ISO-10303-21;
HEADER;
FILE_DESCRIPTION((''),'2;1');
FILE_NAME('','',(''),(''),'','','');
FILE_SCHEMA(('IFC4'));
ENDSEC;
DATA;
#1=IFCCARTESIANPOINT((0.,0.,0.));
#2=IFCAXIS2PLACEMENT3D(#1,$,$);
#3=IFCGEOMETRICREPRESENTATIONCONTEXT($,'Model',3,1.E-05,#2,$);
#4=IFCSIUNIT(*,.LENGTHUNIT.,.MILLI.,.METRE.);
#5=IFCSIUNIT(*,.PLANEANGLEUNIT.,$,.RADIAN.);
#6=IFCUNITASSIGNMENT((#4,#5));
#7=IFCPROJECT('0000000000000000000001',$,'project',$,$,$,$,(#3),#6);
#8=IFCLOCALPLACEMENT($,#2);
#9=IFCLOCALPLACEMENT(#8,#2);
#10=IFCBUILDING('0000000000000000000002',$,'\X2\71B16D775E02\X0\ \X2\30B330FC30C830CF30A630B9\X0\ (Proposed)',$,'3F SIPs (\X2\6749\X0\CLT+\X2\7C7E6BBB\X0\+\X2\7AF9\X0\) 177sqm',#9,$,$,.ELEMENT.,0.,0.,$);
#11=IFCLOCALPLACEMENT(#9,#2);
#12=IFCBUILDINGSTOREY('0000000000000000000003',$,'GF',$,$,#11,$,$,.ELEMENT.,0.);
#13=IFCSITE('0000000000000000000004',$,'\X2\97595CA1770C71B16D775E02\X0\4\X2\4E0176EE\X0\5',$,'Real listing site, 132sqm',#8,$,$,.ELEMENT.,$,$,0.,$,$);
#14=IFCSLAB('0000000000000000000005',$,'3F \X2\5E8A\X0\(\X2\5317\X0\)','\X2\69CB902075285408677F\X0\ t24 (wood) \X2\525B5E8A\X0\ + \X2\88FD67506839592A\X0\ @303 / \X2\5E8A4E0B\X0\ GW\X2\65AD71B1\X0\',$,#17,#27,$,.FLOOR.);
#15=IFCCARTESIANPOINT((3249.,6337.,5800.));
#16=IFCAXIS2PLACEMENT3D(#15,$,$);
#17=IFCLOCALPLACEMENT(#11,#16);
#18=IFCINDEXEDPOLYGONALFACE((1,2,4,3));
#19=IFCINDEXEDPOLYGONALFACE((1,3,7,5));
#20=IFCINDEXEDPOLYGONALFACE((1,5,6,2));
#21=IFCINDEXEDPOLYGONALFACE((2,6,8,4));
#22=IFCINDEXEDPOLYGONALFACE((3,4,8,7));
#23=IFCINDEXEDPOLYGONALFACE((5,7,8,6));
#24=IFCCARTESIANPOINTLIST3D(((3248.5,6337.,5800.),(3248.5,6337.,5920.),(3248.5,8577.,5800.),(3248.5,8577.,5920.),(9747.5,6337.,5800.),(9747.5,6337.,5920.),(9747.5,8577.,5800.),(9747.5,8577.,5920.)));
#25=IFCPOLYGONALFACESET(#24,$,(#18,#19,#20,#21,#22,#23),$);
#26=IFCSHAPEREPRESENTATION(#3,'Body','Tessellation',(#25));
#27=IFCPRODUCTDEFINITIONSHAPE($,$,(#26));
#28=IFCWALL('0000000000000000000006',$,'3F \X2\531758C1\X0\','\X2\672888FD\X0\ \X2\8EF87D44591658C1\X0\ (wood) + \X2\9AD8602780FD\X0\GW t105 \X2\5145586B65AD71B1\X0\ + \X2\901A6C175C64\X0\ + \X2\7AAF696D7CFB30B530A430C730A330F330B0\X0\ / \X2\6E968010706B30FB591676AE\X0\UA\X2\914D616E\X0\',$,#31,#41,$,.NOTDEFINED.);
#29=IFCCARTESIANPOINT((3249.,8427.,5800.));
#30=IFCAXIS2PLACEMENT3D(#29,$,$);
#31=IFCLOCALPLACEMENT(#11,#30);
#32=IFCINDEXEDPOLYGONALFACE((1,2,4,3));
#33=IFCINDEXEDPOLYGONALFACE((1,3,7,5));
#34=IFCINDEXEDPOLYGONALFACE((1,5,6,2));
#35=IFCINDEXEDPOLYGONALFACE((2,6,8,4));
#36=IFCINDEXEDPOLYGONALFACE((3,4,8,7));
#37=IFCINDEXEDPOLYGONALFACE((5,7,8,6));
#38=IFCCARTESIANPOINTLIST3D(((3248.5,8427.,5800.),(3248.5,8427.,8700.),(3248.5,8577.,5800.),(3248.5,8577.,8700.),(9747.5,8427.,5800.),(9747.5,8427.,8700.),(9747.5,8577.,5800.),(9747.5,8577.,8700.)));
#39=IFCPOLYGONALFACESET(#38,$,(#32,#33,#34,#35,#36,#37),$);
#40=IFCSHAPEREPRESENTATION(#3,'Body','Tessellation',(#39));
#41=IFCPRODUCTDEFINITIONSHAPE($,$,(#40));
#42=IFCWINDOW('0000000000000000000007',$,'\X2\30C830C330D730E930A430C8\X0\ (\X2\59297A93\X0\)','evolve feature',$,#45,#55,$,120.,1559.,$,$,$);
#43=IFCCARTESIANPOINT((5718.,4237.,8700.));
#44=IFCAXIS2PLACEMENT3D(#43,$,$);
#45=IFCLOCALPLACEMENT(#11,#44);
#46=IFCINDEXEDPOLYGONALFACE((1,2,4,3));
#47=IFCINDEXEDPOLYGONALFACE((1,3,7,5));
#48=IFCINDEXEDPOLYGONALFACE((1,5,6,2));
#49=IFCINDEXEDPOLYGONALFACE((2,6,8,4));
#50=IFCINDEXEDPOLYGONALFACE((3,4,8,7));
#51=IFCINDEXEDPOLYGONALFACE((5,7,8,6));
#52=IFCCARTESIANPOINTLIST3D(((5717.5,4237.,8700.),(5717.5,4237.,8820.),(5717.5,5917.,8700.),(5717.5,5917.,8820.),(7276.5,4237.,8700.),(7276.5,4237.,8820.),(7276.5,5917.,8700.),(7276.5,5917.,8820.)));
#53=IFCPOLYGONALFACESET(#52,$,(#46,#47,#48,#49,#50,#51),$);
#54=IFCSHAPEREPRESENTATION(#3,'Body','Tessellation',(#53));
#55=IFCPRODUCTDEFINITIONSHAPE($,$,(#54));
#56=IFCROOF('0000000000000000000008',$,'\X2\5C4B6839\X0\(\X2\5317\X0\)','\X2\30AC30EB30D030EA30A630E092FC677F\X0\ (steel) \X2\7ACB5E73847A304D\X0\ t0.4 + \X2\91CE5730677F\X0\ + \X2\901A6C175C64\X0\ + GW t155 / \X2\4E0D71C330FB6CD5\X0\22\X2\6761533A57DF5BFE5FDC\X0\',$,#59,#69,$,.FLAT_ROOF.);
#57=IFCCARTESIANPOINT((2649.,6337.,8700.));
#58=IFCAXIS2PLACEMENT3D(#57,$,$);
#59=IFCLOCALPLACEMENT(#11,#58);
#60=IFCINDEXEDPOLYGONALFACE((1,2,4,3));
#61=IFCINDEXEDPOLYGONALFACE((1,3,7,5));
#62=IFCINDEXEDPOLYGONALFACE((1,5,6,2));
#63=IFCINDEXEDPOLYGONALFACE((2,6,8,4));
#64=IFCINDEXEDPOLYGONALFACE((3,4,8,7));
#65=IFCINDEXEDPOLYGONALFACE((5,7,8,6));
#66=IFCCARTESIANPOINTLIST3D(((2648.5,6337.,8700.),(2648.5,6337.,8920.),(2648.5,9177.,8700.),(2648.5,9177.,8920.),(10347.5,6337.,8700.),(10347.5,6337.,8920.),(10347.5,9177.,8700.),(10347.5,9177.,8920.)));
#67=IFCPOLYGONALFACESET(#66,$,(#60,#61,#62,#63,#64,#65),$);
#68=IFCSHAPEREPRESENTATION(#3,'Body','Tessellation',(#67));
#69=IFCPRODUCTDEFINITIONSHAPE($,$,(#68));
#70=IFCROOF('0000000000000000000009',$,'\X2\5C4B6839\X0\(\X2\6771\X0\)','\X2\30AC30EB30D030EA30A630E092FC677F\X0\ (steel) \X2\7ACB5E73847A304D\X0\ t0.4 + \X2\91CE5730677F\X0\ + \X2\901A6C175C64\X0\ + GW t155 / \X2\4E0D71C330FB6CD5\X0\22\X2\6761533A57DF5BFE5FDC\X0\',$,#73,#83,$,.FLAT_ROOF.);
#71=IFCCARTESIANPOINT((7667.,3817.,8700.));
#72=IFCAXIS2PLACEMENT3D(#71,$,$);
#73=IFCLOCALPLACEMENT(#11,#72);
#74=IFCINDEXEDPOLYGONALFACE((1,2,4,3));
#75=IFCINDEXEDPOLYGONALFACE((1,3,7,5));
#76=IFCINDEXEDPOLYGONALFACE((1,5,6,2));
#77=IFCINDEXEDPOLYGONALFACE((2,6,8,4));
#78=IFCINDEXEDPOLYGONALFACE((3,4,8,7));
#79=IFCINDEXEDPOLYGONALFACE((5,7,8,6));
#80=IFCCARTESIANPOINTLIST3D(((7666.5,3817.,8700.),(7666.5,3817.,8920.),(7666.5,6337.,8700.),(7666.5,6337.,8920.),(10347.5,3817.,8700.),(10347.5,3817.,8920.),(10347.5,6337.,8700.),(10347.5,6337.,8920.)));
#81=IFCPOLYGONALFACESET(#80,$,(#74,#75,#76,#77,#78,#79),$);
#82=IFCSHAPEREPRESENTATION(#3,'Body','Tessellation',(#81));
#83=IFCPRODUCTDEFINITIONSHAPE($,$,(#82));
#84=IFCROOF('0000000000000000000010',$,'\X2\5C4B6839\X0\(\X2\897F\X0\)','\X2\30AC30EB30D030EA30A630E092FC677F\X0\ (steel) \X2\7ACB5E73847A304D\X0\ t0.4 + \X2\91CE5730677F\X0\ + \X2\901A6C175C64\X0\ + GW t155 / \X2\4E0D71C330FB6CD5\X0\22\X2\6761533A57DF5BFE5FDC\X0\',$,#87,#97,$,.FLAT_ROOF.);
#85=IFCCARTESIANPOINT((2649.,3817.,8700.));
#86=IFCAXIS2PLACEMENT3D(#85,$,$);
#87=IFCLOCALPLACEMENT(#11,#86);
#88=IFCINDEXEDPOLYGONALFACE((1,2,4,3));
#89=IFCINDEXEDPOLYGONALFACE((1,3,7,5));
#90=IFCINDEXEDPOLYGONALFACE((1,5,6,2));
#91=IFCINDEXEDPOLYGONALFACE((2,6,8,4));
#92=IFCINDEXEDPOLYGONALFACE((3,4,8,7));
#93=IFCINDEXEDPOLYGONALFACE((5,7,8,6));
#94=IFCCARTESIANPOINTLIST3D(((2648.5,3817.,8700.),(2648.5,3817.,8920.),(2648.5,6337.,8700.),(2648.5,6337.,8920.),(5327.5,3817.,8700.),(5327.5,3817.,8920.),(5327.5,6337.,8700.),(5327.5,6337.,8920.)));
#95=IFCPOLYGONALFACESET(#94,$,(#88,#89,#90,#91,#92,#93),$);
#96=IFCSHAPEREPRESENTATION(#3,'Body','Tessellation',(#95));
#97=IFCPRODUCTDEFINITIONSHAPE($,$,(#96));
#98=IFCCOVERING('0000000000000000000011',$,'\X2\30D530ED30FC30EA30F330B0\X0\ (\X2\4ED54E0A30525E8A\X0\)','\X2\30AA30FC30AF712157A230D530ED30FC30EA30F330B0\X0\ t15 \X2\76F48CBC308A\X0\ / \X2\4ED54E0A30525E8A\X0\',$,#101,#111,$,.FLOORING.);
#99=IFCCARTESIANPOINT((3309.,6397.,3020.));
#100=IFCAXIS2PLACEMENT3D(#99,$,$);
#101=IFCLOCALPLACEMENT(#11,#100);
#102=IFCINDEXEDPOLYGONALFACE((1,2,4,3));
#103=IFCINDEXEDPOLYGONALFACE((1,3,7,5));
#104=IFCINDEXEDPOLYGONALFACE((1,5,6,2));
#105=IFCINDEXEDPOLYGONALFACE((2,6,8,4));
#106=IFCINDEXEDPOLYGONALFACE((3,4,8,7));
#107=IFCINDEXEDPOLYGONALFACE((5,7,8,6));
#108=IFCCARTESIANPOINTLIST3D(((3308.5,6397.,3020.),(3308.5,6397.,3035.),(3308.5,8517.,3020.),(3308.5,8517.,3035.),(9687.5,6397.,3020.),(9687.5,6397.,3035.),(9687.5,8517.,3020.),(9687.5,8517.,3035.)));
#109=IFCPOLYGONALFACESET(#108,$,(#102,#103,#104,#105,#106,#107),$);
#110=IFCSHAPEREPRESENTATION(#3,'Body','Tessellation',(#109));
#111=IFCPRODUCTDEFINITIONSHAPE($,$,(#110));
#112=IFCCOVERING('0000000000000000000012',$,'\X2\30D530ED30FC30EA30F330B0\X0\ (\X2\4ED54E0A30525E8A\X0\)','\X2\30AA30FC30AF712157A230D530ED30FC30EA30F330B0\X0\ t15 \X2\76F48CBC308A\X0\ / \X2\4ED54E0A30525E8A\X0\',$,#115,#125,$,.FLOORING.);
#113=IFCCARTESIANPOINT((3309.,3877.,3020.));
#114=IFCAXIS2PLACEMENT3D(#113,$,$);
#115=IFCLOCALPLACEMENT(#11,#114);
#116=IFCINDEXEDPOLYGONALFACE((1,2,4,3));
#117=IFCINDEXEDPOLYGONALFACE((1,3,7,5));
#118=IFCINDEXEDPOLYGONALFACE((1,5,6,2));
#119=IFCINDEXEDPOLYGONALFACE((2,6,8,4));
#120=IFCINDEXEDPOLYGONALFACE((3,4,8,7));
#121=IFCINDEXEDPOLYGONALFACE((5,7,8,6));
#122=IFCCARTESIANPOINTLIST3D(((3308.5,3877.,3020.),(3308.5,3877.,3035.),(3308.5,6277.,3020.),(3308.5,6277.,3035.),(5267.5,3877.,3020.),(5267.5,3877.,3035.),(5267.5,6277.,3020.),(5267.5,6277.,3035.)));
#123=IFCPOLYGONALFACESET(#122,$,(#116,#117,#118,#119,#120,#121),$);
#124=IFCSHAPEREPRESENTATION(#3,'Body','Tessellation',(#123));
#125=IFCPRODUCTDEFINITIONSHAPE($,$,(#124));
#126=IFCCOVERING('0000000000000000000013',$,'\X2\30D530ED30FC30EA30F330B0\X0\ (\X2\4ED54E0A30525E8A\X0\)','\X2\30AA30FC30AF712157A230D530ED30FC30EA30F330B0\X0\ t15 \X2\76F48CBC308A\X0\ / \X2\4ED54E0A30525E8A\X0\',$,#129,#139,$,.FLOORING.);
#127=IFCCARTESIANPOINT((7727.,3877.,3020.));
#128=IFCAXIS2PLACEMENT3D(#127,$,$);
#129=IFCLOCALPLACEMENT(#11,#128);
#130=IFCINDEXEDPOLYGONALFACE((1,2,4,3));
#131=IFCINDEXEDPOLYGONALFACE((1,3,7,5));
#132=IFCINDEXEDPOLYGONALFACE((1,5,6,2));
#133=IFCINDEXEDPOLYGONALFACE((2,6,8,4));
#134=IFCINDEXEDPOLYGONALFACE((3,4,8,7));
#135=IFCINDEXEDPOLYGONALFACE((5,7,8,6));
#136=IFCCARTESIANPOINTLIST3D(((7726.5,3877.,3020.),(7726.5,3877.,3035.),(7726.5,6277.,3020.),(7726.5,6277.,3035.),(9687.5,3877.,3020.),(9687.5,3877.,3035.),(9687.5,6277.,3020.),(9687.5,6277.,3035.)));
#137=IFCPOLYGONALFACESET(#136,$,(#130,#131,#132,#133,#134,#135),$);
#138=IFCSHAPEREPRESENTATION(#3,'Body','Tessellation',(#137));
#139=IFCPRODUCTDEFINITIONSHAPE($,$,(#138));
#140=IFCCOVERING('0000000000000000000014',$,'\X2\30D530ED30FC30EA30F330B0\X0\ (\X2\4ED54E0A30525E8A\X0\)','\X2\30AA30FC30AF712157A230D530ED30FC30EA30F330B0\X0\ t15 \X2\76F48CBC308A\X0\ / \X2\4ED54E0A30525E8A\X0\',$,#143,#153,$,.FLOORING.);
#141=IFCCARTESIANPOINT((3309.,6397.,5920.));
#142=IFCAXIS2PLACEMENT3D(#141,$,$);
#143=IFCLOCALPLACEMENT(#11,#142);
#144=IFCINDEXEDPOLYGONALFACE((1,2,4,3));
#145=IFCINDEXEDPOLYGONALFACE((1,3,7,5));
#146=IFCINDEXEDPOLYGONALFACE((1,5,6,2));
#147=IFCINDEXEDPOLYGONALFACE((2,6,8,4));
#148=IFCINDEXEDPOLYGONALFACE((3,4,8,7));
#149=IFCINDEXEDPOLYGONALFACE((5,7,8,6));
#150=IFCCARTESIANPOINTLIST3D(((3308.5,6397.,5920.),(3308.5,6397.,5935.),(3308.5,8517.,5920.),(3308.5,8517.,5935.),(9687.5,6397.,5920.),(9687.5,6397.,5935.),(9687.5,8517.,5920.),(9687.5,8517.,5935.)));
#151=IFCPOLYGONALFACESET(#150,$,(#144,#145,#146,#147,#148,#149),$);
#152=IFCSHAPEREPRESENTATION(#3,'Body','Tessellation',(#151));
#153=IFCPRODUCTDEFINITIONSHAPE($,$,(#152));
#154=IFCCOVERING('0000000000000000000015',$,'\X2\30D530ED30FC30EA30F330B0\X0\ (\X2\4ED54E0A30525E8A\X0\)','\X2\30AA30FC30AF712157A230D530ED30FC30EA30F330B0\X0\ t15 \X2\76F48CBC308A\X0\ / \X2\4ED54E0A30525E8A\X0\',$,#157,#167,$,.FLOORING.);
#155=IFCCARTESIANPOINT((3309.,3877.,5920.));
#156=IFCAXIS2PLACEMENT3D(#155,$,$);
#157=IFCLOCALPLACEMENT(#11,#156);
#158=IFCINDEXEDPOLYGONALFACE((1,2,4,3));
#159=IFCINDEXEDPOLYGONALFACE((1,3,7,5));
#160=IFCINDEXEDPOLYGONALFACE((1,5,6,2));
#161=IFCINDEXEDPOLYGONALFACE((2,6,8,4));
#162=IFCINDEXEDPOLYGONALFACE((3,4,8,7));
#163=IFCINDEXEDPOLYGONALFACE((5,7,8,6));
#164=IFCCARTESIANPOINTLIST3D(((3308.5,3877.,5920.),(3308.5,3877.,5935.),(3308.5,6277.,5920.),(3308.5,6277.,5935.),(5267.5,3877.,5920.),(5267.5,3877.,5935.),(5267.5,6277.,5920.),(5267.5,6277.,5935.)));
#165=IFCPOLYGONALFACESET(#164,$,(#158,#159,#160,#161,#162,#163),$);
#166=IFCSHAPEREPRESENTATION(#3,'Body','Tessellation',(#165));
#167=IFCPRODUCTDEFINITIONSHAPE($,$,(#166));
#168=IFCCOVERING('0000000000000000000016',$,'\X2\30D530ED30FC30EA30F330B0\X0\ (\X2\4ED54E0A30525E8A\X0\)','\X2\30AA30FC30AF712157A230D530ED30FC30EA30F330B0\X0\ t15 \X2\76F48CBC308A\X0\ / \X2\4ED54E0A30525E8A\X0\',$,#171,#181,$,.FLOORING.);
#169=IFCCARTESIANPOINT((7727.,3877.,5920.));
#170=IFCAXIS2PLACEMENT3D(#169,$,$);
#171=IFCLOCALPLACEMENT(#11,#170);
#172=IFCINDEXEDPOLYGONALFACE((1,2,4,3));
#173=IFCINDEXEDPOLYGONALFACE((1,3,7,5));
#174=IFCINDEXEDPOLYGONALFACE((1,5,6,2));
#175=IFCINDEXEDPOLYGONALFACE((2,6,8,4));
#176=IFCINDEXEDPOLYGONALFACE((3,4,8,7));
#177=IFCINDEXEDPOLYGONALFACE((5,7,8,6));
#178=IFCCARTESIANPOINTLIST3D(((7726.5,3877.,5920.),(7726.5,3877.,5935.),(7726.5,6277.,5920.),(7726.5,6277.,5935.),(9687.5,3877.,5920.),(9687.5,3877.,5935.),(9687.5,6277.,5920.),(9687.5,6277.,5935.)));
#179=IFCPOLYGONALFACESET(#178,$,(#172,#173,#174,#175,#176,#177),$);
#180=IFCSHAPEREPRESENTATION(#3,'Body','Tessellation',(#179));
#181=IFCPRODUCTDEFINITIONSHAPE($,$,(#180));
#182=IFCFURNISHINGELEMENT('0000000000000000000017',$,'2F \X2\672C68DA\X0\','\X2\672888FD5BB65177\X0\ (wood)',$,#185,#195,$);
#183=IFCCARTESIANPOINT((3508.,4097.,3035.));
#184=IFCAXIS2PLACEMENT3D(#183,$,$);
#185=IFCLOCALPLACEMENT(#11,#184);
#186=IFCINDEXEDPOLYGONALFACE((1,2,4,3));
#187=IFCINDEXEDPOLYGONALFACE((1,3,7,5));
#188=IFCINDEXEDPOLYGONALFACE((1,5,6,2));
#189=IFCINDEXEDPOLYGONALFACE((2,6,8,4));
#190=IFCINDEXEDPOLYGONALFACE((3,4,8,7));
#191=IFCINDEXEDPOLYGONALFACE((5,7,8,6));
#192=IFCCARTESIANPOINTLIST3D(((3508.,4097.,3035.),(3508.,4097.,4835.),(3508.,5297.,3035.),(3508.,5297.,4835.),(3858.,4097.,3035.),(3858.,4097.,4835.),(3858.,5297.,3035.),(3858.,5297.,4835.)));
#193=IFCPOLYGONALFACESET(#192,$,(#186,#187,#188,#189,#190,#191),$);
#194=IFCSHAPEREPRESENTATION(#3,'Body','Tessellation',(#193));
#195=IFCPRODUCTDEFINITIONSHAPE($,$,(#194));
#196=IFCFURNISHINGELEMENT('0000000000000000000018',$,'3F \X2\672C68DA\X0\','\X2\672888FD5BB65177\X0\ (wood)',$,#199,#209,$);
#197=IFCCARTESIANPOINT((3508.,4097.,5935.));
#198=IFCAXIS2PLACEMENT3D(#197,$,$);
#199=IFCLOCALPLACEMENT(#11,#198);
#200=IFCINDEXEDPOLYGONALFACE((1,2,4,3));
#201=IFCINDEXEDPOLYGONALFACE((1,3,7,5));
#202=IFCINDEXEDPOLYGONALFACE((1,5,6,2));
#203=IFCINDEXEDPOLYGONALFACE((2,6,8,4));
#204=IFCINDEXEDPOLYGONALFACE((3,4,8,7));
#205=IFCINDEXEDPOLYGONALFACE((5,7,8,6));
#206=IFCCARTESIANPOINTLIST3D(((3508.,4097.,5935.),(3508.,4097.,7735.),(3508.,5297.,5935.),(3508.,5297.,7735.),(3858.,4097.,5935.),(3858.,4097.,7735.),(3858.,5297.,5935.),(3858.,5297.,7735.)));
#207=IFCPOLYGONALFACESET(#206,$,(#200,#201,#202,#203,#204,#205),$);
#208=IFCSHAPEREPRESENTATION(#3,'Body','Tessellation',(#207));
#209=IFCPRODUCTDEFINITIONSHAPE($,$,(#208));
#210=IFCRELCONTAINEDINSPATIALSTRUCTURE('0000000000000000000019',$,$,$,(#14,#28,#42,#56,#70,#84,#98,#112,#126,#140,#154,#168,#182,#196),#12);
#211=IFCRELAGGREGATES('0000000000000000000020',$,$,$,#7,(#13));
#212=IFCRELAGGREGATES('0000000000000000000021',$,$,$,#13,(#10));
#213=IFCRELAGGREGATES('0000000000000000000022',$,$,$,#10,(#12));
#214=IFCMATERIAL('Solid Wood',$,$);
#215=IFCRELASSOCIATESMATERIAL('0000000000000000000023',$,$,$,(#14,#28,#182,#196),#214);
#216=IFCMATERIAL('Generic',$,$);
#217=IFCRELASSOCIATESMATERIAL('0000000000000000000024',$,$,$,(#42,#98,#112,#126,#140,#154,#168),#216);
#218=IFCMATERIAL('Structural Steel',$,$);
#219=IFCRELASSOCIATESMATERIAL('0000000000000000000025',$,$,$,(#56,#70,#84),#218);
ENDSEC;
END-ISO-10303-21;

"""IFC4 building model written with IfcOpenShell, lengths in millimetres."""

from ifc_helpers import new_model, si_unit, frame, frame_2d, origin, place, context, project, spatial, rectangle, extrude, material, element, save


model = new_model("IFC4")

# Units and contexts
model_context = context("Model", 3, precision=1e-05, world=origin())
ifc_project = project(units=[si_unit("LENGTHUNIT", "METRE", prefix="MILLI"), si_unit("PLANEANGLEUNIT", "RADIAN")], contexts=[model_context])

# Site, building, storey
site_placement = place(None, origin())
site = spatial("IfcSite", under=ifc_project, at=site_placement, Name="静岡県熱海市4丁目5", ObjectType="Real listing site, 132sqm", CompositionType="ELEMENT", RefElevation=0.0)
building_placement = place(site_placement, origin())
building = spatial("IfcBuilding", under=site, at=building_placement, Name="熱海市 コートハウス (Proposed)", ObjectType="3F SIPs (杉CLT+籾殻+竹) 177sqm", CompositionType="ELEMENT", ElevationOfRefHeight=0.0, ElevationOfTerrain=0.0)
storey_placement = place(building_placement, origin())
storey = spatial("IfcBuildingStorey", under=building, at=storey_placement, Name="GF", CompositionType="ELEMENT", Elevation=0.0)

# Slab
ifc_material_1 = material(Name="Solid Wood")
slab_placement = place(storey_placement, frame((3249.0, 6337.0, 5800.0)))
element("IfcSlab", 1, at=slab_placement, inside=storey, material=ifc_material_1, Name="3F 床(北)", Description="構造用合板 t24 (wood) 剛床 + 製材根太 @303 / 床下 GW断熱", PredefinedType="FLOOR", context=model_context, shape_type="SweptSolid", body=[
    extrude(rectangle(XDim=6499.0, YDim=2240.0, at=frame_2d((3249.0, 1120.0))), frame((3249.0, 6337.0, 5800.0)), (0.0, 0.0, 1.0), 120.0),
])

# Wall
wall_1_placement = place(storey_placement, frame((3249.0, 8427.0, 5800.0)))
element("IfcWall", 2, at=wall_1_placement, inside=storey, material=ifc_material_1, Name="3F 北壁", Description="木製 軸組外壁 (wood) + 高性能GW t105 充填断熱 + 通気層 + 窯業系サイディング / 準耐火・外皮UA配慮", PredefinedType="NOTDEFINED", context=model_context, shape_type="SweptSolid", body=[
    extrude(rectangle(XDim=6499.0, YDim=150.0, at=frame_2d((3249.0, 75.0))), frame((3249.0, 8427.0, 5800.0)), (0.0, 0.0, 1.0), 2900.0),
])

# Window
ifc_material_2 = material(Name="Generic")
window_1_placement = place(storey_placement, frame((5718.0, 4237.0, 8700.0)))
element("IfcWindow", 3, at=window_1_placement, inside=storey, material=ifc_material_2, Name="トップライト (天窓)", Description="evolve feature", OverallHeight=120.0, OverallWidth=1559.0, context=model_context, shape_type="SweptSolid", body=[
    extrude(rectangle(XDim=1559.0, YDim=1680.0, at=frame_2d((779.0, 840.0))), frame((5718.0, 4237.0, 8700.0)), (0.0, 0.0, 1.0), 120.0),
])

# Roofs
ifc_material_3 = material(Name="Structural Steel")
roof_1_placement = place(storey_placement, frame((2649.0, 6337.0, 8700.0)))
element("IfcRoof", 4, at=roof_1_placement, inside=storey, material=ifc_material_3, Name="屋根(北)", Description="ガルバリウム鋼板 (steel) 立平葺き t0.4 + 野地板 + 通気層 + GW t155 / 不燃・法22条区域対応", PredefinedType="FLAT_ROOF", context=model_context, shape_type="SweptSolid", body=[
    extrude(rectangle(XDim=7699.0, YDim=2840.0, at=frame_2d((3849.0, 1420.0))), frame((2649.0, 6337.0, 8700.0)), (0.0, 0.0, 1.0), 220.0),
])
roof_2_placement = place(storey_placement, frame((7667.0, 3817.0, 8700.0)))
element("IfcRoof", 5, at=roof_2_placement, inside=storey, material=ifc_material_3, Name="屋根(東)", Description="ガルバリウム鋼板 (steel) 立平葺き t0.4 + 野地板 + 通気層 + GW t155 / 不燃・法22条区域対応", PredefinedType="FLAT_ROOF", context=model_context, shape_type="SweptSolid", body=[
    extrude(rectangle(XDim=2681.0, YDim=2520.0, at=frame_2d((1340.0, 1260.0))), frame((7667.0, 3817.0, 8700.0)), (0.0, 0.0, 1.0), 220.0),
])
roof_3_placement = place(storey_placement, frame((2649.0, 3817.0, 8700.0)))
element("IfcRoof", 6, at=roof_3_placement, inside=storey, material=ifc_material_3, Name="屋根(西)", Description="ガルバリウム鋼板 (steel) 立平葺き t0.4 + 野地板 + 通気層 + GW t155 / 不燃・法22条区域対応", PredefinedType="FLAT_ROOF", context=model_context, shape_type="SweptSolid", body=[
    extrude(rectangle(XDim=2679.0, YDim=2520.0, at=frame_2d((1339.0, 1260.0))), frame((2649.0, 3817.0, 8700.0)), (0.0, 0.0, 1.0), 220.0),
])

# Coverings
covering_1_placement = place(storey_placement, frame((3309.0, 6397.0, 3020.0)))
element("IfcCovering", 7, at=covering_1_placement, inside=storey, material=ifc_material_2, Name="フローリング (仕上げ床)", Description="オーク無垢フローリング t15 直貼り / 仕上げ床", PredefinedType="FLOORING", context=model_context, shape_type="SweptSolid", body=[
    extrude(rectangle(XDim=6379.0, YDim=2120.0, at=frame_2d((3189.0, 1060.0))), frame((3309.0, 6397.0, 3020.0)), (0.0, 0.0, 1.0), 15.0),
])
covering_2_placement = place(storey_placement, frame((3309.0, 3877.0, 3020.0)))
element("IfcCovering", 8, at=covering_2_placement, inside=storey, material=ifc_material_2, Name="フローリング (仕上げ床)", Description="オーク無垢フローリング t15 直貼り / 仕上げ床", PredefinedType="FLOORING", context=model_context, shape_type="SweptSolid", body=[
    extrude(rectangle(XDim=1959.0, YDim=2400.0, at=frame_2d((979.0, 1200.0))), frame((3309.0, 3877.0, 3020.0)), (0.0, 0.0, 1.0), 15.0),
])
covering_3_placement = place(storey_placement, frame((7727.0, 3877.0, 3020.0)))
element("IfcCovering", 9, at=covering_3_placement, inside=storey, material=ifc_material_2, Name="フローリング (仕上げ床)", Description="オーク無垢フローリング t15 直貼り / 仕上げ床", PredefinedType="FLOORING", context=model_context, shape_type="SweptSolid", body=[
    extrude(rectangle(XDim=1961.0, YDim=2400.0, at=frame_2d((980.0, 1200.0))), frame((7727.0, 3877.0, 3020.0)), (0.0, 0.0, 1.0), 15.0),
])
covering_4_placement = place(storey_placement, frame((3309.0, 6397.0, 5920.0)))
element("IfcCovering", 10, at=covering_4_placement, inside=storey, material=ifc_material_2, Name="フローリング (仕上げ床)", Description="オーク無垢フローリング t15 直貼り / 仕上げ床", PredefinedType="FLOORING", context=model_context, shape_type="SweptSolid", body=[
    extrude(rectangle(XDim=6379.0, YDim=2120.0, at=frame_2d((3189.0, 1060.0))), frame((3309.0, 6397.0, 5920.0)), (0.0, 0.0, 1.0), 15.0),
])
covering_5_placement = place(storey_placement, frame((3309.0, 3877.0, 5920.0)))
element("IfcCovering", 11, at=covering_5_placement, inside=storey, material=ifc_material_2, Name="フローリング (仕上げ床)", Description="オーク無垢フローリング t15 直貼り / 仕上げ床", PredefinedType="FLOORING", context=model_context, shape_type="SweptSolid", body=[
    extrude(rectangle(XDim=1959.0, YDim=2400.0, at=frame_2d((979.0, 1200.0))), frame((3309.0, 3877.0, 5920.0)), (0.0, 0.0, 1.0), 15.0),
])
covering_6_placement = place(storey_placement, frame((7727.0, 3877.0, 5920.0)))
element("IfcCovering", 12, at=covering_6_placement, inside=storey, material=ifc_material_2, Name="フローリング (仕上げ床)", Description="オーク無垢フローリング t15 直貼り / 仕上げ床", PredefinedType="FLOORING", context=model_context, shape_type="SweptSolid", body=[
    extrude(rectangle(XDim=1961.0, YDim=2400.0, at=frame_2d((980.0, 1200.0))), frame((7727.0, 3877.0, 5920.0)), (0.0, 0.0, 1.0), 15.0),
])

# Furnishing elements
furnishing_1_placement = place(storey_placement, frame((3508.0, 4097.0, 3035.0)))
element("IfcFurnishingElement", 13, at=furnishing_1_placement, inside=storey, material=ifc_material_1, Name="2F 本棚", Description="木製家具 (wood)", context=model_context, shape_type="SweptSolid", body=[
    extrude(rectangle(XDim=350.0, YDim=1200.0, at=frame_2d((175.0, 600.0))), frame((3508.0, 4097.0, 3035.0)), (0.0, 0.0, 1.0), 1800.0),
])
furnishing_2_placement = place(storey_placement, frame((3508.0, 4097.0, 5935.0)))
element("IfcFurnishingElement", 14, at=furnishing_2_placement, inside=storey, material=ifc_material_1, Name="3F 本棚", Description="木製家具 (wood)", context=model_context, shape_type="SweptSolid", body=[
    extrude(rectangle(XDim=350.0, YDim=1200.0, at=frame_2d((175.0, 600.0))), frame((3508.0, 4097.0, 5935.0)), (0.0, 0.0, 1.0), 1800.0),
])

save(model, "model.ifc")
